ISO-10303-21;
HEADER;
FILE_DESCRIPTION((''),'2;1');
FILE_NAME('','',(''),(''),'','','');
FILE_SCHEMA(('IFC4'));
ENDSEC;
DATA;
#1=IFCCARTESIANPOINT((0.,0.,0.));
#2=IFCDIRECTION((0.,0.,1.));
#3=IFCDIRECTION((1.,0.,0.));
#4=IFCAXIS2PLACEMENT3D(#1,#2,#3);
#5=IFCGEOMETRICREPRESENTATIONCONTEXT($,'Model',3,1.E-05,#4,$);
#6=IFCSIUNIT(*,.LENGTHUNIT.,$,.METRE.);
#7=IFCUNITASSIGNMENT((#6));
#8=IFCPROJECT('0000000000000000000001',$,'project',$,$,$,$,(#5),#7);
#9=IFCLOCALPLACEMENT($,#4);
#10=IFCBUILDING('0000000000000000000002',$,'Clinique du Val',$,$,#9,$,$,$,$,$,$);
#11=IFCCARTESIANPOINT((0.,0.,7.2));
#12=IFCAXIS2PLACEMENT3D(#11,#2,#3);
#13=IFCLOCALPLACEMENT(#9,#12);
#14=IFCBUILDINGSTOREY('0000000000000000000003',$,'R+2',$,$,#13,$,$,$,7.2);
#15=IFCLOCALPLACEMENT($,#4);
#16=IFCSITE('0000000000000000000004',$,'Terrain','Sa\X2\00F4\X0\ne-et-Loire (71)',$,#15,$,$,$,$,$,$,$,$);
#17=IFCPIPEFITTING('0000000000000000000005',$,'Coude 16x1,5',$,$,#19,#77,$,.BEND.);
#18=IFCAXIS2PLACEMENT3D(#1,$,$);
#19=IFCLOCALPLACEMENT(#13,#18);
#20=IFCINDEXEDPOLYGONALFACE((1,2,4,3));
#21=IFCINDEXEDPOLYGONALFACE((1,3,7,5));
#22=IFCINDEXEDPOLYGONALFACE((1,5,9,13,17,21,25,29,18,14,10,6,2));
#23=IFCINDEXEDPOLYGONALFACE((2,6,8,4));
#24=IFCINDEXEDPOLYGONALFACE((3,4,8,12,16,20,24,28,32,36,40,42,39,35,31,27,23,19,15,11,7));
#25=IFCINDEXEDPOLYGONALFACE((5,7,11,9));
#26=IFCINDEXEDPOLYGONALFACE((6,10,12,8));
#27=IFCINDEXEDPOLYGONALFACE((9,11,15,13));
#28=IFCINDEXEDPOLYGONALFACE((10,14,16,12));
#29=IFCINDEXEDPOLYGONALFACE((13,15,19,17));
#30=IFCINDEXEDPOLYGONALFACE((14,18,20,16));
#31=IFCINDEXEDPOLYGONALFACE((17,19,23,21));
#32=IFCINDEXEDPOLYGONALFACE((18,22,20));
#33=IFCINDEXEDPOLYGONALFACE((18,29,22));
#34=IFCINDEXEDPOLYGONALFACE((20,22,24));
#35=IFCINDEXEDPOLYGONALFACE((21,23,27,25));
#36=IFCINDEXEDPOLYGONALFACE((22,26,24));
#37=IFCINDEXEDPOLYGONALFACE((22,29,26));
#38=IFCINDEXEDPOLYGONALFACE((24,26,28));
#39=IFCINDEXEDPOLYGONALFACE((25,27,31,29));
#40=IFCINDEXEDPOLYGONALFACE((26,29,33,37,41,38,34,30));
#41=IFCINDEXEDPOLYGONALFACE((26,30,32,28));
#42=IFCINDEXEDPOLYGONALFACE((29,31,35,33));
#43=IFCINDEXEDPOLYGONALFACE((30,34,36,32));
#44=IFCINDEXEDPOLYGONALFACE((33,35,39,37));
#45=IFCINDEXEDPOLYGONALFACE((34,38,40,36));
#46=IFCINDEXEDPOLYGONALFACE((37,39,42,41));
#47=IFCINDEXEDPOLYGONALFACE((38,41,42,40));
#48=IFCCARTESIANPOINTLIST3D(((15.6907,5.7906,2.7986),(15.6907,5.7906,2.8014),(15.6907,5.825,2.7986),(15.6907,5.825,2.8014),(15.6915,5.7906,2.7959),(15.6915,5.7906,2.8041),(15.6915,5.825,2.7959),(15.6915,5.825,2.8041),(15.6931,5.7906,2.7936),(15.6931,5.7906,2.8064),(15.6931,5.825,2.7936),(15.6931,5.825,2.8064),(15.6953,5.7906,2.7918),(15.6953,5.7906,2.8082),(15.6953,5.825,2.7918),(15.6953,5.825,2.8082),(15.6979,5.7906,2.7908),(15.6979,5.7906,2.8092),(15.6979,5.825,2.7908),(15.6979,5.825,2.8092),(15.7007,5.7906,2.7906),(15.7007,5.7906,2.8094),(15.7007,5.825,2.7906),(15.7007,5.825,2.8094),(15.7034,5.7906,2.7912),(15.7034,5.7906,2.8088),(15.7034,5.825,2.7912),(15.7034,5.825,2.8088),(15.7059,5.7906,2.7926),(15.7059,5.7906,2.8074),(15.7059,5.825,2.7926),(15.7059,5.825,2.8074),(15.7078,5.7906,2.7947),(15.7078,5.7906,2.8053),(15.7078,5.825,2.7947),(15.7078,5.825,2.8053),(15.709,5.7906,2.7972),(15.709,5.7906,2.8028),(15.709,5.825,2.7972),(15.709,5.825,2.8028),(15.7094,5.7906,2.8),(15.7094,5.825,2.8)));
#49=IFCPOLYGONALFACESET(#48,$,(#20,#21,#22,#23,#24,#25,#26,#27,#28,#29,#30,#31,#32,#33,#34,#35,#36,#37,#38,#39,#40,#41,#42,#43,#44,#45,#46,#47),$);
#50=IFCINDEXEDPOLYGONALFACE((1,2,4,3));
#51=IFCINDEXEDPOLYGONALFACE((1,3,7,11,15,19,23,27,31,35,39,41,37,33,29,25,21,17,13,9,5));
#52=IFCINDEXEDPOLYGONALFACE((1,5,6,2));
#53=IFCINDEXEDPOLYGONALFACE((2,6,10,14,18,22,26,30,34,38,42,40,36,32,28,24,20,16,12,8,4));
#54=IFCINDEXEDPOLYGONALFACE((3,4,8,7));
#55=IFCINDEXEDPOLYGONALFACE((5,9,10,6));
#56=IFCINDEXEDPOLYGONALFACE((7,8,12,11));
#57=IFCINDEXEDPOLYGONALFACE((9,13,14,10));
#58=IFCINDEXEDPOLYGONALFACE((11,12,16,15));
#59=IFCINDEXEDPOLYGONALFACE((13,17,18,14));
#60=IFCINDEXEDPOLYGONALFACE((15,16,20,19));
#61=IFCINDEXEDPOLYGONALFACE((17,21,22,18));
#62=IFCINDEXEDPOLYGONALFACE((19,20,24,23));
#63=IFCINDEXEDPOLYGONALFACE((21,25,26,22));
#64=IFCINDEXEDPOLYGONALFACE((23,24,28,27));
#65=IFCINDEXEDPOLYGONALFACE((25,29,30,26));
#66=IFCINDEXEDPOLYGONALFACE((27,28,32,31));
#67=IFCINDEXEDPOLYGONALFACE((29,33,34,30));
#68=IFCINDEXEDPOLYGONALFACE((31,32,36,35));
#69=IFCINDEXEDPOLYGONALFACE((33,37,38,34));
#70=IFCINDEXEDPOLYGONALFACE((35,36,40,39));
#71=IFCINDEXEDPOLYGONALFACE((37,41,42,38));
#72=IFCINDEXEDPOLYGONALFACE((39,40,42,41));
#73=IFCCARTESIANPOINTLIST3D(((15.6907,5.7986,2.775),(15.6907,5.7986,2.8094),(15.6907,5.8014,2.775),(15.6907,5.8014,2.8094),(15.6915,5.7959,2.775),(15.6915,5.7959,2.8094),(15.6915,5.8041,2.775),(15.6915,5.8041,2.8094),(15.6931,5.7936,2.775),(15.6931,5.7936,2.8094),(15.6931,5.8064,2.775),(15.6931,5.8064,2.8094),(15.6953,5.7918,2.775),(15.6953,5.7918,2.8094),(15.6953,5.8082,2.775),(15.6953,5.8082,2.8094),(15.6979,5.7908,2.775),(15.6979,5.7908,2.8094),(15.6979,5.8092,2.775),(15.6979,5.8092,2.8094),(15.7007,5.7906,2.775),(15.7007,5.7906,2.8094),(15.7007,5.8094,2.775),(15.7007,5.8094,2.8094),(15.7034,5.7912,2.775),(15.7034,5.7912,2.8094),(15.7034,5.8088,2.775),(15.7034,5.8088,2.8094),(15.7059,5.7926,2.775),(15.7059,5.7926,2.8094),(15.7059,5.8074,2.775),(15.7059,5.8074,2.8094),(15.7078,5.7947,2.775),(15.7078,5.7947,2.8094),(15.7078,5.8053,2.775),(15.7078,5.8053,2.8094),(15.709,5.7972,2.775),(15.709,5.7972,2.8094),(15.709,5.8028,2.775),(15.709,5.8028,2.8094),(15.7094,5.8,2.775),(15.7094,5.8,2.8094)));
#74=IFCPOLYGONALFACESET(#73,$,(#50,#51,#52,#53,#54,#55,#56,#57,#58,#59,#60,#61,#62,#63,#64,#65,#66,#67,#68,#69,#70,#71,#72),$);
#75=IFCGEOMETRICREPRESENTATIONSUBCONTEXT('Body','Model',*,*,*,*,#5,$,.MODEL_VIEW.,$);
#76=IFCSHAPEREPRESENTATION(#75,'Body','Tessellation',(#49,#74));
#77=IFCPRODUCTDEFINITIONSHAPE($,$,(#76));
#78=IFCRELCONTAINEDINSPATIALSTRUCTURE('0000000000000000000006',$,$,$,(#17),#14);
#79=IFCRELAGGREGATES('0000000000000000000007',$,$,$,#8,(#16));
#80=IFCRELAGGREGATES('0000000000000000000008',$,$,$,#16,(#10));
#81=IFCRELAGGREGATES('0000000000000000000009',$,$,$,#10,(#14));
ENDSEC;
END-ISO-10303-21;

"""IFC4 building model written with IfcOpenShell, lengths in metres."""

from ifc_helpers import new_model, si_unit, frame, origin_with_axes, place, context, subcontext, project, spatial, circle, extrude, element, save


model = new_model("IFC4")

# Units and contexts
model_context = context("Model", 3, precision=1e-05, world=origin_with_axes())
body_context = subcontext(model_context, "Body", "Model", "MODEL_VIEW")
ifc_project = project(units=[si_unit("LENGTHUNIT", "METRE")], contexts=[model_context])

# Site, building, storey
site_placement = place(None, origin_with_axes())
site = spatial("IfcSite", under=ifc_project, at=site_placement, Name="Terrain", Description="Saône-et-Loire (71)")
building_placement = place(None, origin_with_axes())
building = spatial("IfcBuilding", under=site, at=building_placement, Name="Clinique du Val")
storey_placement = place(building_placement, frame((0.0, 0.0, 7.2), z_axis=(0.0, 0.0, 1.0), x_axis=(1.0, 0.0, 0.0)))
storey = spatial("IfcBuildingStorey", under=building, at=storey_placement, Name="R+2", Elevation=7.2)

# Pipe fitting
pipe_fitting_placement = place(storey_placement, frame((15.7, 5.8, 2.8), z_axis=(0.0, 0.0, 1.0), x_axis=(1.0, 0.0, 0.0)))
element("IfcPipeFitting", 1, at=pipe_fitting_placement, inside=storey, Name="Coude 16x1,5", PredefinedType="BEND", context=body_context, shape_type="SweptSolid", body=[
    extrude(circle(Radius=0.0094), frame((0.0, -0.0094, 0.0), z_axis=(0.0, 1.0, 0.0), x_axis=(1.0, 0.0, 0.0)), (0.0, 0.0, 1.0), 0.0344),
    extrude(circle(Radius=0.0094), frame((0.0, 0.0, 0.0094), z_axis=(0.0, 0.0, -1.0), x_axis=(1.0, 0.0, 0.0)), (0.0, 0.0, 1.0), 0.0344),
])

save(model, "model.ifc")
